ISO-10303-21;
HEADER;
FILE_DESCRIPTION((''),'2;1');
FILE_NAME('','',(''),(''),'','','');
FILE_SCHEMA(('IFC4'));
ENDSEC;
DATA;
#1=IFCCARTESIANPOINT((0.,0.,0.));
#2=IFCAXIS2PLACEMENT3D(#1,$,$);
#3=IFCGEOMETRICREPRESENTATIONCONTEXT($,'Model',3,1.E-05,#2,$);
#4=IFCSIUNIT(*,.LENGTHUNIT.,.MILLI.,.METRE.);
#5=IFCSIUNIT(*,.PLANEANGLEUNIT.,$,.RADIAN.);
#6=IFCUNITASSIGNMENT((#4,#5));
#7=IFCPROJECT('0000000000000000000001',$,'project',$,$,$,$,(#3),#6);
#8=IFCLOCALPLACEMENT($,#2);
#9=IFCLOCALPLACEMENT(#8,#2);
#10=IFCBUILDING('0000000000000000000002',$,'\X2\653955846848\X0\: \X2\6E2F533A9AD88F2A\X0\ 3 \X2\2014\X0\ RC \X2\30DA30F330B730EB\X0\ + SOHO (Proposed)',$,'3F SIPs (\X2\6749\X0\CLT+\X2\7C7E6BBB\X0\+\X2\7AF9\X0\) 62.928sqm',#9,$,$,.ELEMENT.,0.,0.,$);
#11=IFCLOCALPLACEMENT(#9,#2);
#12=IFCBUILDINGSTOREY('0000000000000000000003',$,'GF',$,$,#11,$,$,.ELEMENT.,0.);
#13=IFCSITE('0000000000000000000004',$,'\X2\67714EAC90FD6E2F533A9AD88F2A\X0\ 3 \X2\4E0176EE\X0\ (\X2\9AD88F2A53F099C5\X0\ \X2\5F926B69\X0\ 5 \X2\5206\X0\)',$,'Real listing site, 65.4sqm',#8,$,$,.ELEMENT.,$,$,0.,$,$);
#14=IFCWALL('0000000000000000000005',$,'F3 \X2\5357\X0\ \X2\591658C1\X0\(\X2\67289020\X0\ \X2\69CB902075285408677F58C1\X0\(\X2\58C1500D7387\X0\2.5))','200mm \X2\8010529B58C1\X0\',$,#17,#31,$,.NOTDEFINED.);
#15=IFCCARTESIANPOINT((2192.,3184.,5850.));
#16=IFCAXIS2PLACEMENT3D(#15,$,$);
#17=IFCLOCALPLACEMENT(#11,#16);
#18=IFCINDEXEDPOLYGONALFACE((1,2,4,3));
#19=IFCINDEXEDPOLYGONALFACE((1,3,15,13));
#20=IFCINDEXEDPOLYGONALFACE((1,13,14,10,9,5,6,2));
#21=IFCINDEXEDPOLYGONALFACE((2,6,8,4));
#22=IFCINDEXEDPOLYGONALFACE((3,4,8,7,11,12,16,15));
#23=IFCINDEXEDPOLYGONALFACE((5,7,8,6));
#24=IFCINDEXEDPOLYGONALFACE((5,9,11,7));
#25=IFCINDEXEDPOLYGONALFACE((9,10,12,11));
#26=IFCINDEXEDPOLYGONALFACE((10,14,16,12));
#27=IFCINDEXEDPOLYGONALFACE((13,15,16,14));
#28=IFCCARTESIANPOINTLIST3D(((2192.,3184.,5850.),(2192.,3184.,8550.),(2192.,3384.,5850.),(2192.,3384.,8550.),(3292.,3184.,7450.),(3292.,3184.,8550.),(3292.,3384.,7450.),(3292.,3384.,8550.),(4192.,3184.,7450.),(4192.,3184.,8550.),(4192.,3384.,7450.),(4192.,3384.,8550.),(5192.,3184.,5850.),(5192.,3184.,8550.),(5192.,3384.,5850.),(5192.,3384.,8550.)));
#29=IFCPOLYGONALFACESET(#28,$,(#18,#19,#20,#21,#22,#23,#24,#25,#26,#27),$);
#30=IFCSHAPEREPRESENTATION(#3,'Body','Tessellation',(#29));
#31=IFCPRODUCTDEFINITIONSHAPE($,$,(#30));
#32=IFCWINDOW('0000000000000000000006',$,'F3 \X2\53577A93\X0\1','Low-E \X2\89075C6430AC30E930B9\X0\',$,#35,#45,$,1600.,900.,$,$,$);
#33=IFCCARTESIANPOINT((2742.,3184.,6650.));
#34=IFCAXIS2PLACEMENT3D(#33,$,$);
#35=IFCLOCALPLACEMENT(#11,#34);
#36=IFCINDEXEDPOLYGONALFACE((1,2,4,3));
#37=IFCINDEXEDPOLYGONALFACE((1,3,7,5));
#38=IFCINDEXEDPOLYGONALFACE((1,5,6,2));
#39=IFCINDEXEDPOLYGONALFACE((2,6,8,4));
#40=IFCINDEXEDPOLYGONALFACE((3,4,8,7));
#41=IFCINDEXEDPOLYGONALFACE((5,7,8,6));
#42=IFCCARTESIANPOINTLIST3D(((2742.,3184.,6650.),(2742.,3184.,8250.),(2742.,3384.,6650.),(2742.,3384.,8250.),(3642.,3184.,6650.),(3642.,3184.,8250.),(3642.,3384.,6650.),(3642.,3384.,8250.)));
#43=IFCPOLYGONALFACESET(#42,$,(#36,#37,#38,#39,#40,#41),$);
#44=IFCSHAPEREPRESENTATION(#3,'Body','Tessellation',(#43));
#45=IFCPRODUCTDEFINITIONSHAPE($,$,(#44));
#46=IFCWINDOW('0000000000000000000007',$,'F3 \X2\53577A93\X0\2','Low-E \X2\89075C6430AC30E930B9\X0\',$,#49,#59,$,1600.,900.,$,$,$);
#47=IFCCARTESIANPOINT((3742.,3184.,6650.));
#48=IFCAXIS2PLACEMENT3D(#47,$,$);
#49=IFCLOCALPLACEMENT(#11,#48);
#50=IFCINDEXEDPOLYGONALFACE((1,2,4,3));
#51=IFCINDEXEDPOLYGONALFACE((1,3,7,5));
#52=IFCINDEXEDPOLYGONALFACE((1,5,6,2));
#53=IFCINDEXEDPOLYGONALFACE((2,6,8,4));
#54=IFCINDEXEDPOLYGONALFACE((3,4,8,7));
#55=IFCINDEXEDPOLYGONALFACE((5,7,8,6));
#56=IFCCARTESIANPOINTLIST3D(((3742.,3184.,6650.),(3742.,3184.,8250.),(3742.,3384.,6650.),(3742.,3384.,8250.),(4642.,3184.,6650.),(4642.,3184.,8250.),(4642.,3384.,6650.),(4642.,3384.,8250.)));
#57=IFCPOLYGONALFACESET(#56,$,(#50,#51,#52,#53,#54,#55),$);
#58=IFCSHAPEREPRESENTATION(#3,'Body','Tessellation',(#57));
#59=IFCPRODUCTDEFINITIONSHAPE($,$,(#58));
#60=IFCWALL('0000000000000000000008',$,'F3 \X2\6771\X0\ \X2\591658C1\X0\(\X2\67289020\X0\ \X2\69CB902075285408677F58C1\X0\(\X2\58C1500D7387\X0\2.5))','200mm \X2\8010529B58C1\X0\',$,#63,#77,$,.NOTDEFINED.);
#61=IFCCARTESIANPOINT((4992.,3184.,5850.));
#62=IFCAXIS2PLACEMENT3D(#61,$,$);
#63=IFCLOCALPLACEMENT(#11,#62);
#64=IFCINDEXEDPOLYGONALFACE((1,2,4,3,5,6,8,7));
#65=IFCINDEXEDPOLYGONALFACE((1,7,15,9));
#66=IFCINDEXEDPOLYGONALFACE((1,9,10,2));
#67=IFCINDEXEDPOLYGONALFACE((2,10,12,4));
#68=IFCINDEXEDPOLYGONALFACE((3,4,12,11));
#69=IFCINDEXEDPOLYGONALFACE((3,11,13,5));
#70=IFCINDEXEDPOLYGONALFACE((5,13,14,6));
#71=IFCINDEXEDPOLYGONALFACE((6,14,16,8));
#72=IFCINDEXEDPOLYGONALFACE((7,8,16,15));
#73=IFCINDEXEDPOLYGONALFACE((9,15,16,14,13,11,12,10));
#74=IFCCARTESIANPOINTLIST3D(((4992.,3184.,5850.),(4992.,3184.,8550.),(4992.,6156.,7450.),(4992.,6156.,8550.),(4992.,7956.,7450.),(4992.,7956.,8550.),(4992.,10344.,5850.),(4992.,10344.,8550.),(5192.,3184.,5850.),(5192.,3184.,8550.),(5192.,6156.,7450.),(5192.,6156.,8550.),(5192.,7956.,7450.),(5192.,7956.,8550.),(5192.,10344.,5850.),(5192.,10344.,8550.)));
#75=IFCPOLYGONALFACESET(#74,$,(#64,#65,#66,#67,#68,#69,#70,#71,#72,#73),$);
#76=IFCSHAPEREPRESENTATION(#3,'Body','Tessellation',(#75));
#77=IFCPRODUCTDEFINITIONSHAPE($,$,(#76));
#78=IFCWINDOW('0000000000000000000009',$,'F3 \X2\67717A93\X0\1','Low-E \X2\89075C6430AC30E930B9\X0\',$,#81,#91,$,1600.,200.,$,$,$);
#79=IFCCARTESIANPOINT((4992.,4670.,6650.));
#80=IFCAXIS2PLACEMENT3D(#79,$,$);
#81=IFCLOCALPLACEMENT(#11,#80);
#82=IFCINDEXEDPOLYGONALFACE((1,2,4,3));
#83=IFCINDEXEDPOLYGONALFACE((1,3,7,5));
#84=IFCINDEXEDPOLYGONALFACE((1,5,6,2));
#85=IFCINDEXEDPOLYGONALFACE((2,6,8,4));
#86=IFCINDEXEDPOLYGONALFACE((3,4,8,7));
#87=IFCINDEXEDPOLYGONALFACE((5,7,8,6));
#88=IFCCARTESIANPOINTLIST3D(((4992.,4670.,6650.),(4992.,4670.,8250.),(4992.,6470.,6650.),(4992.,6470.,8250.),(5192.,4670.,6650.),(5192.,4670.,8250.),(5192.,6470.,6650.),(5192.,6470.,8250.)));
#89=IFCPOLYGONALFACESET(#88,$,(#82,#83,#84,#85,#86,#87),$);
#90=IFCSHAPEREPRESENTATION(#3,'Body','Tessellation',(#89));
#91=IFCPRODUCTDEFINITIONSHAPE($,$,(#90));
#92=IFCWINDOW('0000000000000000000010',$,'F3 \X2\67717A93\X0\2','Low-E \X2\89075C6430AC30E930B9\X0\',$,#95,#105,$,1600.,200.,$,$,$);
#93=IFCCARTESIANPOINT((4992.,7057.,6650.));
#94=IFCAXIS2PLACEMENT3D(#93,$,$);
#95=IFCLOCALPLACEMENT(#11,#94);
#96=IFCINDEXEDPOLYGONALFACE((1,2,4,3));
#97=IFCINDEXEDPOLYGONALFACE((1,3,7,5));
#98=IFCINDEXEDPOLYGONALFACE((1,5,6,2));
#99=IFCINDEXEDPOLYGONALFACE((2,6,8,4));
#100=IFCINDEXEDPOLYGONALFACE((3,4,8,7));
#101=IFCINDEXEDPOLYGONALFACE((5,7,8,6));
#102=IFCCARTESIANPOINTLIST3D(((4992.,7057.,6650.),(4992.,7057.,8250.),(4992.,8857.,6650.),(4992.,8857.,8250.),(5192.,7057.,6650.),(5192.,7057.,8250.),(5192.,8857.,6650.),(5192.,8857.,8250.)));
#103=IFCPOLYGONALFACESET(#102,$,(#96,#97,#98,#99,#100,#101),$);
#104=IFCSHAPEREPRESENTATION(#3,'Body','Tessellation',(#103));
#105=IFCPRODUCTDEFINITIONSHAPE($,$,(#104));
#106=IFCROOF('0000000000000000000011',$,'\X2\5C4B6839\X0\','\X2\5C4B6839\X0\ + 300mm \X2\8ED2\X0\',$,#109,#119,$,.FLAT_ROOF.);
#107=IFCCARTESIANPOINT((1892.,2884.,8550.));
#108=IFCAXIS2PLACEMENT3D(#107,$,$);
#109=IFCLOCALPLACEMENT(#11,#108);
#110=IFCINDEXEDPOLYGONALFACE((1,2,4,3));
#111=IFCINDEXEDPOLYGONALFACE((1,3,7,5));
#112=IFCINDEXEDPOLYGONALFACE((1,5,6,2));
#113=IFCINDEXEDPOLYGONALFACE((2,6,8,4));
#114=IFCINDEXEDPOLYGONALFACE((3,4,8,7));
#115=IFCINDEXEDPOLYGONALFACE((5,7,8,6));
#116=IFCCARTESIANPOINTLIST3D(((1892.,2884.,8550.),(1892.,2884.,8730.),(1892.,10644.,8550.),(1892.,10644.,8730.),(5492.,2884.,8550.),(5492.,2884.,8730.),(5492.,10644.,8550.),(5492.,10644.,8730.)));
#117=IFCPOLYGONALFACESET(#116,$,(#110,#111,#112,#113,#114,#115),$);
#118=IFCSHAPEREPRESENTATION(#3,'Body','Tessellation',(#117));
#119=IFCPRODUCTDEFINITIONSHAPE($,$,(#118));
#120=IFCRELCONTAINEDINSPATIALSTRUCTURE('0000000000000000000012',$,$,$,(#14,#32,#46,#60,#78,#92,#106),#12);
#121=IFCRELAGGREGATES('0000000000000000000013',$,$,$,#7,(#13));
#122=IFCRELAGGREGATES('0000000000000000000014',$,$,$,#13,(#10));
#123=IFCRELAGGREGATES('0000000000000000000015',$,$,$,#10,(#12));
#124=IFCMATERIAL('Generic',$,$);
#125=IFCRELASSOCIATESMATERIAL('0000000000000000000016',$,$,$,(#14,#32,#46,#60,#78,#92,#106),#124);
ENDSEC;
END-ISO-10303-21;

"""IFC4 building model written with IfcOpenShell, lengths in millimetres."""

from ifc_helpers import new_model, si_unit, frame, frame_2d, origin, place, context, project, spatial, rectangle, extrude, material, element, fill, save


model = new_model("IFC4")

# Units and contexts
model_context = context("Model", 3, precision=1e-05, world=origin())
ifc_project = project(units=[si_unit("LENGTHUNIT", "METRE", prefix="MILLI"), si_unit("PLANEANGLEUNIT", "RADIAN")], contexts=[model_context])

# Site, building, storey
site_placement = place(None, origin())
site = spatial("IfcSite", under=ifc_project, at=site_placement, Name="東京都港区高輪 3 丁目 (高輪台駅 徒歩 5 分)", ObjectType="Real listing site, 65.4sqm", CompositionType="ELEMENT", RefElevation=0.0)
building_placement = place(site_placement, origin())
building = spatial("IfcBuilding", under=site, at=building_placement, Name="改善案: 港区高輪 3 — RC ペンシル + SOHO (Proposed)", ObjectType="3F SIPs (杉CLT+籾殻+竹) 62.928sqm", CompositionType="ELEMENT", ElevationOfRefHeight=0.0, ElevationOfTerrain=0.0)
storey_placement = place(building_placement, origin())
storey = spatial("IfcBuildingStorey", under=building, at=storey_placement, Name="GF", CompositionType="ELEMENT", Elevation=0.0)

# Shared definitions
ifc_material = material(Name="Generic")

# Walls, openings, windows
wall_1_placement = place(storey_placement, frame((2192.0, 3184.0, 5850.0)))
wall_1 = element("IfcWall", 1, at=wall_1_placement, inside=storey, material=ifc_material, Name="F3 南 外壁(木造 構造用合板壁(壁倍率2.5))", Description="200mm 耐力壁", PredefinedType="NOTDEFINED", context=model_context, shape_type="SweptSolid", body=[
    extrude(rectangle(XDim=3000.0, YDim=200.0, at=frame_2d((1500.0, 100.0))), frame((2192.0, 3184.0, 5850.0)), (0.0, 0.0, 1.0), 2700.0),
])
opening_1_placement = place(storey_placement, frame((2742.0, 3184.0, 6650.0)))
opening_1 = element("IfcOpeningElement", 2, at=opening_1_placement, cuts=wall_1, PredefinedType="NOTDEFINED", context=model_context, shape_type="SweptSolid", body=[
    extrude(rectangle(XDim=900.0, YDim=200.0, at=frame_2d((450.0, 100.0))), frame((2742.0, 3184.0, 6650.0)), (0.0, 0.0, 1.0), 1600.0),
])
opening_2_placement = place(storey_placement, frame((3742.0, 3184.0, 6650.0)))
opening_2 = element("IfcOpeningElement", 3, at=opening_2_placement, cuts=wall_1, PredefinedType="NOTDEFINED", context=model_context, shape_type="SweptSolid", body=[
    extrude(rectangle(XDim=900.0, YDim=200.0, at=frame_2d((450.0, 100.0))), frame((3742.0, 3184.0, 6650.0)), (0.0, 0.0, 1.0), 1600.0),
])
window_1_placement = place(storey_placement, frame((2742.0, 3184.0, 6650.0)))
window_1 = element("IfcWindow", 4, at=window_1_placement, inside=storey, material=ifc_material, Name="F3 南窓1", Description="Low-E 複層ガラス", OverallHeight=1600.0, OverallWidth=900.0, context=model_context, shape_type="SweptSolid", body=[
    extrude(rectangle(XDim=900.0, YDim=200.0, at=frame_2d((450.0, 100.0))), frame((2742.0, 3184.0, 6650.0)), (0.0, 0.0, 1.0), 1600.0),
])
fill(opening_1, window_1)
window_2_placement = place(storey_placement, frame((3742.0, 3184.0, 6650.0)))
window_2 = element("IfcWindow", 5, at=window_2_placement, inside=storey, material=ifc_material, Name="F3 南窓2", Description="Low-E 複層ガラス", OverallHeight=1600.0, OverallWidth=900.0, context=model_context, shape_type="SweptSolid", body=[
    extrude(rectangle(XDim=900.0, YDim=200.0, at=frame_2d((450.0, 100.0))), frame((3742.0, 3184.0, 6650.0)), (0.0, 0.0, 1.0), 1600.0),
])
fill(opening_2, window_2)
wall_2_placement = place(storey_placement, frame((4992.0, 3184.0, 5850.0)))
wall_2 = element("IfcWall", 6, at=wall_2_placement, inside=storey, material=ifc_material, Name="F3 東 外壁(木造 構造用合板壁(壁倍率2.5))", Description="200mm 耐力壁", PredefinedType="NOTDEFINED", context=model_context, shape_type="SweptSolid", body=[
    extrude(rectangle(XDim=200.0, YDim=7160.0, at=frame_2d((100.0, 3580.0))), frame((4992.0, 3184.0, 5850.0)), (0.0, 0.0, 1.0), 2700.0),
])
opening_3_placement = place(storey_placement, frame((4992.0, 4670.0, 6650.0)))
opening_3 = element("IfcOpeningElement", 7, at=opening_3_placement, cuts=wall_2, PredefinedType="NOTDEFINED", context=model_context, shape_type="SweptSolid", body=[
    extrude(rectangle(XDim=200.0, YDim=1800.0, at=frame_2d((100.0, 900.0))), frame((4992.0, 4670.0, 6650.0)), (0.0, 0.0, 1.0), 1600.0),
])
opening_4_placement = place(storey_placement, frame((4992.0, 7057.0, 6650.0)))
opening_4 = element("IfcOpeningElement", 8, at=opening_4_placement, cuts=wall_2, PredefinedType="NOTDEFINED", context=model_context, shape_type="SweptSolid", body=[
    extrude(rectangle(XDim=200.0, YDim=1800.0, at=frame_2d((100.0, 900.0))), frame((4992.0, 7057.0, 6650.0)), (0.0, 0.0, 1.0), 1600.0),
])
window_3_placement = place(storey_placement, frame((4992.0, 4670.0, 6650.0)))
window_3 = element("IfcWindow", 9, at=window_3_placement, inside=storey, material=ifc_material, Name="F3 東窓1", Description="Low-E 複層ガラス", OverallHeight=1600.0, OverallWidth=200.0, context=model_context, shape_type="SweptSolid", body=[
    extrude(rectangle(XDim=200.0, YDim=1800.0, at=frame_2d((100.0, 900.0))), frame((4992.0, 4670.0, 6650.0)), (0.0, 0.0, 1.0), 1600.0),
])
fill(opening_3, window_3)
window_4_placement = place(storey_placement, frame((4992.0, 7057.0, 6650.0)))
window_4 = element("IfcWindow", 10, at=window_4_placement, inside=storey, material=ifc_material, Name="F3 東窓2", Description="Low-E 複層ガラス", OverallHeight=1600.0, OverallWidth=200.0, context=model_context, shape_type="SweptSolid", body=[
    extrude(rectangle(XDim=200.0, YDim=1800.0, at=frame_2d((100.0, 900.0))), frame((4992.0, 7057.0, 6650.0)), (0.0, 0.0, 1.0), 1600.0),
])
fill(opening_4, window_4)

# Roof
roof_placement = place(storey_placement, frame((1892.0, 2884.0, 8550.0)))
element("IfcRoof", 11, at=roof_placement, inside=storey, material=ifc_material, Name="屋根", Description="屋根 + 300mm 軒", PredefinedType="FLAT_ROOF", context=model_context, shape_type="SweptSolid", body=[
    extrude(rectangle(XDim=3600.0, YDim=7760.0, at=frame_2d((1800.0, 3880.0))), frame((1892.0, 2884.0, 8550.0)), (0.0, 0.0, 1.0), 180.0),
])

save(model, "model.ifc")
